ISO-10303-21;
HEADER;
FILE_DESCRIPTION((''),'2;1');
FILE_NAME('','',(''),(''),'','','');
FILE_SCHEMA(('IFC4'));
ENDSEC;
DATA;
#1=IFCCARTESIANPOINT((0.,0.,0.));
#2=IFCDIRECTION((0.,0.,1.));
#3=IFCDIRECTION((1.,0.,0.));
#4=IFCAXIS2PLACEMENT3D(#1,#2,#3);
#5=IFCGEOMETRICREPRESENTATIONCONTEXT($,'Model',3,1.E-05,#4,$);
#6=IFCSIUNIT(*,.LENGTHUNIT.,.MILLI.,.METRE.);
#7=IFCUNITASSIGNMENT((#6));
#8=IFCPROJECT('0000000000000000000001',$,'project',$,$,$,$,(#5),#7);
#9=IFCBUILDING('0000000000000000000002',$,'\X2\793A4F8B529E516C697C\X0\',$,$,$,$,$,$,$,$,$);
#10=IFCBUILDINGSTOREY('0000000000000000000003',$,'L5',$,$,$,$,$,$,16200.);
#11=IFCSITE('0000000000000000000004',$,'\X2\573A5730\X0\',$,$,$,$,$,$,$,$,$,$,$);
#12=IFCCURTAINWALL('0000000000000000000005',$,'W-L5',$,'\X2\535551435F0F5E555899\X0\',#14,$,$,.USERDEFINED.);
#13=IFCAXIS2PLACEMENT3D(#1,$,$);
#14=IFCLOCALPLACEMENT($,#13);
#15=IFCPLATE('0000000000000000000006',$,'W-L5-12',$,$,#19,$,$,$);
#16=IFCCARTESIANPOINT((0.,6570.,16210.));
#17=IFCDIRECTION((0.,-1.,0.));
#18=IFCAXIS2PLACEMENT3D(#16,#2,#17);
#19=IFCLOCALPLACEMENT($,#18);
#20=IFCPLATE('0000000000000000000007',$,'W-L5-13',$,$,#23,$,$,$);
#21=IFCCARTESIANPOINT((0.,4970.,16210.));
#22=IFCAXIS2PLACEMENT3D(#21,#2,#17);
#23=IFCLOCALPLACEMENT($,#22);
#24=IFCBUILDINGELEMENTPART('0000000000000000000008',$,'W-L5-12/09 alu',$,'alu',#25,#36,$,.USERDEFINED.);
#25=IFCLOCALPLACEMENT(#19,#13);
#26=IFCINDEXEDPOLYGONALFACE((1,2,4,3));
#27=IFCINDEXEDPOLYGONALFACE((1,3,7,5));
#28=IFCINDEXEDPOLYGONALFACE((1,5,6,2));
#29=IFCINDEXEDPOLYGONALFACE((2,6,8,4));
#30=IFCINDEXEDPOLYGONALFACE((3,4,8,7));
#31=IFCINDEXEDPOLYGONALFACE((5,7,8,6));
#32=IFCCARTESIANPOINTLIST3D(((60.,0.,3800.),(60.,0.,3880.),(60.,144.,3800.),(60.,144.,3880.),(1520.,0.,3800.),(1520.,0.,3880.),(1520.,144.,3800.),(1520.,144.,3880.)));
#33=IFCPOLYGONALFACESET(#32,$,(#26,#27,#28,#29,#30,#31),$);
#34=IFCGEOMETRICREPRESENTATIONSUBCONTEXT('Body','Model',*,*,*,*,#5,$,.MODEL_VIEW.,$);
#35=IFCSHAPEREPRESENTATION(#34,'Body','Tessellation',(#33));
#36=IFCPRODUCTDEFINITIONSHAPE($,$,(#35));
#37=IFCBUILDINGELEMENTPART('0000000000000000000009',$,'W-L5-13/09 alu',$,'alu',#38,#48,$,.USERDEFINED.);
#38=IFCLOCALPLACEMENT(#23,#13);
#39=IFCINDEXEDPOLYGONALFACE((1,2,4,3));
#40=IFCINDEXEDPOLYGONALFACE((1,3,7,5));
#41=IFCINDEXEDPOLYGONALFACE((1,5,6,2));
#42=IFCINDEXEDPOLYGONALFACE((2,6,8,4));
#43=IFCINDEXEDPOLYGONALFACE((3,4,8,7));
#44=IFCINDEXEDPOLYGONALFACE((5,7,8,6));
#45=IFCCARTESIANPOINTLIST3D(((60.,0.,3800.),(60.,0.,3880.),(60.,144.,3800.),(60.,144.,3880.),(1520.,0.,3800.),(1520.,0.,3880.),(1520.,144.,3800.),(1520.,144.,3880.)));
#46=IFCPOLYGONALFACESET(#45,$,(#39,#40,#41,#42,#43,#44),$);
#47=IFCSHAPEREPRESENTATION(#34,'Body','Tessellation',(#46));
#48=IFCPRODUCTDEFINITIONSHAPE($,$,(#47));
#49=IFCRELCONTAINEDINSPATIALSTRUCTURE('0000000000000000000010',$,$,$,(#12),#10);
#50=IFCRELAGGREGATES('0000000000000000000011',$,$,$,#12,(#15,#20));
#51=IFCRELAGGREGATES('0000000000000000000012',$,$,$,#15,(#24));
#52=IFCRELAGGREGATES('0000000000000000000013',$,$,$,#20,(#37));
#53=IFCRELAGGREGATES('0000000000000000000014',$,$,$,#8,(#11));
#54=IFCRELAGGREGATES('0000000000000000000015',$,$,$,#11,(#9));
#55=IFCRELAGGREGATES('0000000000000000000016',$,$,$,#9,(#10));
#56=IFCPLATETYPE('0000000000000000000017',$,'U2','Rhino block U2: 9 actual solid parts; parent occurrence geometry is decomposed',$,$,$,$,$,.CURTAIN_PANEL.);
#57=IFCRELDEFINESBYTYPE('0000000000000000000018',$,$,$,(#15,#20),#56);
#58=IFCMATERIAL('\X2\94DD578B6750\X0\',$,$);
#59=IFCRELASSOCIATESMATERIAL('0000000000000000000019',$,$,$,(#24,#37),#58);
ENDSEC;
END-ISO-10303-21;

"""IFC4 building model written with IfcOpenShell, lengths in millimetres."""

from ifc_helpers import new_model, si_unit, frame, frame_2d, origin, origin_with_axes, place, context, subcontext, project, spatial, rectangle, extrude, source, transform, mapped, material, type_object, element, aggregate, save


model = new_model("IFC4")

# Units and contexts
model_context = context("Model", 3, precision=1e-05, world=origin_with_axes())
body_context = subcontext(model_context, "Body", "Model", "MODEL_VIEW")
ifc_project = project(units=[si_unit("LENGTHUNIT", "METRE", prefix="MILLI")], contexts=[model_context])

# Site, building, storey
site = spatial("IfcSite", under=ifc_project, Name="场地")
building = spatial("IfcBuilding", under=site, Name="示例办公楼")
storey = spatial("IfcBuildingStorey", under=building, Name="L5", Elevation=16200.0)

# Curtain wall, plates, building element parts
curtain_wall = element("IfcCurtainWall", 1, inside=storey, Name="W-L5", ObjectType="单元式幕墙", PredefinedType="USERDEFINED")
plate_type = type_object("IfcPlateType", Name="U2", Description="Rhino block U2: 9 actual solid parts; parent occurrence geometry is decomposed", PredefinedType="CURTAIN_PANEL")
ifc_material_1 = material(Name="铝型材")
plate_1_placement = place(None, frame((0.0, 6570.0, 16210.0), z_axis=(0.0, 0.0, 1.0), x_axis=(0.0, -1.0, 0.0)))
plate_1 = element("IfcPlate", 2, at=plate_1_placement, type_object=plate_type, Name="W-L5-12")
plate_2_placement = place(None, frame((0.0, 4970.0, 16210.0), z_axis=(0.0, 0.0, 1.0), x_axis=(0.0, -1.0, 0.0)))
plate_2 = element("IfcPlate", 3, at=plate_2_placement, type_object=plate_type, Name="W-L5-13")
aggregate(curtain_wall, [plate_1, plate_2])
shared_shape_1 = source(origin(), body_context, "Body", "SweptSolid", [
    extrude(rectangle(XDim=1460.0, YDim=144.0, at=frame_2d((790.0, 72.0))), frame((0.0, 0.0, 3800.0)), (0.0, 0.0, 1.0), 80.0),
])
building_element_part_1_placement = place(plate_1_placement, origin())
building_element_part_1 = element("IfcBuildingElementPart", 4, at=building_element_part_1_placement, material=ifc_material_1, Name="W-L5-12/09 alu", ObjectType="alu", PredefinedType="USERDEFINED", context=body_context, shape_type="MappedRepresentation", body=[
    mapped(shared_shape_1, transform((0.0, 0.0, 0.0))),
])
aggregate(plate_1, [building_element_part_1])
building_element_part_2_placement = place(plate_2_placement, origin())
building_element_part_2 = element("IfcBuildingElementPart", 5, at=building_element_part_2_placement, material=ifc_material_1, Name="W-L5-13/09 alu", ObjectType="alu", PredefinedType="USERDEFINED", context=body_context, shape_type="MappedRepresentation", body=[
    mapped(shared_shape_1, transform((0.0, 0.0, 0.0))),
])
aggregate(plate_2, [building_element_part_2])

save(model, "model.ifc")
